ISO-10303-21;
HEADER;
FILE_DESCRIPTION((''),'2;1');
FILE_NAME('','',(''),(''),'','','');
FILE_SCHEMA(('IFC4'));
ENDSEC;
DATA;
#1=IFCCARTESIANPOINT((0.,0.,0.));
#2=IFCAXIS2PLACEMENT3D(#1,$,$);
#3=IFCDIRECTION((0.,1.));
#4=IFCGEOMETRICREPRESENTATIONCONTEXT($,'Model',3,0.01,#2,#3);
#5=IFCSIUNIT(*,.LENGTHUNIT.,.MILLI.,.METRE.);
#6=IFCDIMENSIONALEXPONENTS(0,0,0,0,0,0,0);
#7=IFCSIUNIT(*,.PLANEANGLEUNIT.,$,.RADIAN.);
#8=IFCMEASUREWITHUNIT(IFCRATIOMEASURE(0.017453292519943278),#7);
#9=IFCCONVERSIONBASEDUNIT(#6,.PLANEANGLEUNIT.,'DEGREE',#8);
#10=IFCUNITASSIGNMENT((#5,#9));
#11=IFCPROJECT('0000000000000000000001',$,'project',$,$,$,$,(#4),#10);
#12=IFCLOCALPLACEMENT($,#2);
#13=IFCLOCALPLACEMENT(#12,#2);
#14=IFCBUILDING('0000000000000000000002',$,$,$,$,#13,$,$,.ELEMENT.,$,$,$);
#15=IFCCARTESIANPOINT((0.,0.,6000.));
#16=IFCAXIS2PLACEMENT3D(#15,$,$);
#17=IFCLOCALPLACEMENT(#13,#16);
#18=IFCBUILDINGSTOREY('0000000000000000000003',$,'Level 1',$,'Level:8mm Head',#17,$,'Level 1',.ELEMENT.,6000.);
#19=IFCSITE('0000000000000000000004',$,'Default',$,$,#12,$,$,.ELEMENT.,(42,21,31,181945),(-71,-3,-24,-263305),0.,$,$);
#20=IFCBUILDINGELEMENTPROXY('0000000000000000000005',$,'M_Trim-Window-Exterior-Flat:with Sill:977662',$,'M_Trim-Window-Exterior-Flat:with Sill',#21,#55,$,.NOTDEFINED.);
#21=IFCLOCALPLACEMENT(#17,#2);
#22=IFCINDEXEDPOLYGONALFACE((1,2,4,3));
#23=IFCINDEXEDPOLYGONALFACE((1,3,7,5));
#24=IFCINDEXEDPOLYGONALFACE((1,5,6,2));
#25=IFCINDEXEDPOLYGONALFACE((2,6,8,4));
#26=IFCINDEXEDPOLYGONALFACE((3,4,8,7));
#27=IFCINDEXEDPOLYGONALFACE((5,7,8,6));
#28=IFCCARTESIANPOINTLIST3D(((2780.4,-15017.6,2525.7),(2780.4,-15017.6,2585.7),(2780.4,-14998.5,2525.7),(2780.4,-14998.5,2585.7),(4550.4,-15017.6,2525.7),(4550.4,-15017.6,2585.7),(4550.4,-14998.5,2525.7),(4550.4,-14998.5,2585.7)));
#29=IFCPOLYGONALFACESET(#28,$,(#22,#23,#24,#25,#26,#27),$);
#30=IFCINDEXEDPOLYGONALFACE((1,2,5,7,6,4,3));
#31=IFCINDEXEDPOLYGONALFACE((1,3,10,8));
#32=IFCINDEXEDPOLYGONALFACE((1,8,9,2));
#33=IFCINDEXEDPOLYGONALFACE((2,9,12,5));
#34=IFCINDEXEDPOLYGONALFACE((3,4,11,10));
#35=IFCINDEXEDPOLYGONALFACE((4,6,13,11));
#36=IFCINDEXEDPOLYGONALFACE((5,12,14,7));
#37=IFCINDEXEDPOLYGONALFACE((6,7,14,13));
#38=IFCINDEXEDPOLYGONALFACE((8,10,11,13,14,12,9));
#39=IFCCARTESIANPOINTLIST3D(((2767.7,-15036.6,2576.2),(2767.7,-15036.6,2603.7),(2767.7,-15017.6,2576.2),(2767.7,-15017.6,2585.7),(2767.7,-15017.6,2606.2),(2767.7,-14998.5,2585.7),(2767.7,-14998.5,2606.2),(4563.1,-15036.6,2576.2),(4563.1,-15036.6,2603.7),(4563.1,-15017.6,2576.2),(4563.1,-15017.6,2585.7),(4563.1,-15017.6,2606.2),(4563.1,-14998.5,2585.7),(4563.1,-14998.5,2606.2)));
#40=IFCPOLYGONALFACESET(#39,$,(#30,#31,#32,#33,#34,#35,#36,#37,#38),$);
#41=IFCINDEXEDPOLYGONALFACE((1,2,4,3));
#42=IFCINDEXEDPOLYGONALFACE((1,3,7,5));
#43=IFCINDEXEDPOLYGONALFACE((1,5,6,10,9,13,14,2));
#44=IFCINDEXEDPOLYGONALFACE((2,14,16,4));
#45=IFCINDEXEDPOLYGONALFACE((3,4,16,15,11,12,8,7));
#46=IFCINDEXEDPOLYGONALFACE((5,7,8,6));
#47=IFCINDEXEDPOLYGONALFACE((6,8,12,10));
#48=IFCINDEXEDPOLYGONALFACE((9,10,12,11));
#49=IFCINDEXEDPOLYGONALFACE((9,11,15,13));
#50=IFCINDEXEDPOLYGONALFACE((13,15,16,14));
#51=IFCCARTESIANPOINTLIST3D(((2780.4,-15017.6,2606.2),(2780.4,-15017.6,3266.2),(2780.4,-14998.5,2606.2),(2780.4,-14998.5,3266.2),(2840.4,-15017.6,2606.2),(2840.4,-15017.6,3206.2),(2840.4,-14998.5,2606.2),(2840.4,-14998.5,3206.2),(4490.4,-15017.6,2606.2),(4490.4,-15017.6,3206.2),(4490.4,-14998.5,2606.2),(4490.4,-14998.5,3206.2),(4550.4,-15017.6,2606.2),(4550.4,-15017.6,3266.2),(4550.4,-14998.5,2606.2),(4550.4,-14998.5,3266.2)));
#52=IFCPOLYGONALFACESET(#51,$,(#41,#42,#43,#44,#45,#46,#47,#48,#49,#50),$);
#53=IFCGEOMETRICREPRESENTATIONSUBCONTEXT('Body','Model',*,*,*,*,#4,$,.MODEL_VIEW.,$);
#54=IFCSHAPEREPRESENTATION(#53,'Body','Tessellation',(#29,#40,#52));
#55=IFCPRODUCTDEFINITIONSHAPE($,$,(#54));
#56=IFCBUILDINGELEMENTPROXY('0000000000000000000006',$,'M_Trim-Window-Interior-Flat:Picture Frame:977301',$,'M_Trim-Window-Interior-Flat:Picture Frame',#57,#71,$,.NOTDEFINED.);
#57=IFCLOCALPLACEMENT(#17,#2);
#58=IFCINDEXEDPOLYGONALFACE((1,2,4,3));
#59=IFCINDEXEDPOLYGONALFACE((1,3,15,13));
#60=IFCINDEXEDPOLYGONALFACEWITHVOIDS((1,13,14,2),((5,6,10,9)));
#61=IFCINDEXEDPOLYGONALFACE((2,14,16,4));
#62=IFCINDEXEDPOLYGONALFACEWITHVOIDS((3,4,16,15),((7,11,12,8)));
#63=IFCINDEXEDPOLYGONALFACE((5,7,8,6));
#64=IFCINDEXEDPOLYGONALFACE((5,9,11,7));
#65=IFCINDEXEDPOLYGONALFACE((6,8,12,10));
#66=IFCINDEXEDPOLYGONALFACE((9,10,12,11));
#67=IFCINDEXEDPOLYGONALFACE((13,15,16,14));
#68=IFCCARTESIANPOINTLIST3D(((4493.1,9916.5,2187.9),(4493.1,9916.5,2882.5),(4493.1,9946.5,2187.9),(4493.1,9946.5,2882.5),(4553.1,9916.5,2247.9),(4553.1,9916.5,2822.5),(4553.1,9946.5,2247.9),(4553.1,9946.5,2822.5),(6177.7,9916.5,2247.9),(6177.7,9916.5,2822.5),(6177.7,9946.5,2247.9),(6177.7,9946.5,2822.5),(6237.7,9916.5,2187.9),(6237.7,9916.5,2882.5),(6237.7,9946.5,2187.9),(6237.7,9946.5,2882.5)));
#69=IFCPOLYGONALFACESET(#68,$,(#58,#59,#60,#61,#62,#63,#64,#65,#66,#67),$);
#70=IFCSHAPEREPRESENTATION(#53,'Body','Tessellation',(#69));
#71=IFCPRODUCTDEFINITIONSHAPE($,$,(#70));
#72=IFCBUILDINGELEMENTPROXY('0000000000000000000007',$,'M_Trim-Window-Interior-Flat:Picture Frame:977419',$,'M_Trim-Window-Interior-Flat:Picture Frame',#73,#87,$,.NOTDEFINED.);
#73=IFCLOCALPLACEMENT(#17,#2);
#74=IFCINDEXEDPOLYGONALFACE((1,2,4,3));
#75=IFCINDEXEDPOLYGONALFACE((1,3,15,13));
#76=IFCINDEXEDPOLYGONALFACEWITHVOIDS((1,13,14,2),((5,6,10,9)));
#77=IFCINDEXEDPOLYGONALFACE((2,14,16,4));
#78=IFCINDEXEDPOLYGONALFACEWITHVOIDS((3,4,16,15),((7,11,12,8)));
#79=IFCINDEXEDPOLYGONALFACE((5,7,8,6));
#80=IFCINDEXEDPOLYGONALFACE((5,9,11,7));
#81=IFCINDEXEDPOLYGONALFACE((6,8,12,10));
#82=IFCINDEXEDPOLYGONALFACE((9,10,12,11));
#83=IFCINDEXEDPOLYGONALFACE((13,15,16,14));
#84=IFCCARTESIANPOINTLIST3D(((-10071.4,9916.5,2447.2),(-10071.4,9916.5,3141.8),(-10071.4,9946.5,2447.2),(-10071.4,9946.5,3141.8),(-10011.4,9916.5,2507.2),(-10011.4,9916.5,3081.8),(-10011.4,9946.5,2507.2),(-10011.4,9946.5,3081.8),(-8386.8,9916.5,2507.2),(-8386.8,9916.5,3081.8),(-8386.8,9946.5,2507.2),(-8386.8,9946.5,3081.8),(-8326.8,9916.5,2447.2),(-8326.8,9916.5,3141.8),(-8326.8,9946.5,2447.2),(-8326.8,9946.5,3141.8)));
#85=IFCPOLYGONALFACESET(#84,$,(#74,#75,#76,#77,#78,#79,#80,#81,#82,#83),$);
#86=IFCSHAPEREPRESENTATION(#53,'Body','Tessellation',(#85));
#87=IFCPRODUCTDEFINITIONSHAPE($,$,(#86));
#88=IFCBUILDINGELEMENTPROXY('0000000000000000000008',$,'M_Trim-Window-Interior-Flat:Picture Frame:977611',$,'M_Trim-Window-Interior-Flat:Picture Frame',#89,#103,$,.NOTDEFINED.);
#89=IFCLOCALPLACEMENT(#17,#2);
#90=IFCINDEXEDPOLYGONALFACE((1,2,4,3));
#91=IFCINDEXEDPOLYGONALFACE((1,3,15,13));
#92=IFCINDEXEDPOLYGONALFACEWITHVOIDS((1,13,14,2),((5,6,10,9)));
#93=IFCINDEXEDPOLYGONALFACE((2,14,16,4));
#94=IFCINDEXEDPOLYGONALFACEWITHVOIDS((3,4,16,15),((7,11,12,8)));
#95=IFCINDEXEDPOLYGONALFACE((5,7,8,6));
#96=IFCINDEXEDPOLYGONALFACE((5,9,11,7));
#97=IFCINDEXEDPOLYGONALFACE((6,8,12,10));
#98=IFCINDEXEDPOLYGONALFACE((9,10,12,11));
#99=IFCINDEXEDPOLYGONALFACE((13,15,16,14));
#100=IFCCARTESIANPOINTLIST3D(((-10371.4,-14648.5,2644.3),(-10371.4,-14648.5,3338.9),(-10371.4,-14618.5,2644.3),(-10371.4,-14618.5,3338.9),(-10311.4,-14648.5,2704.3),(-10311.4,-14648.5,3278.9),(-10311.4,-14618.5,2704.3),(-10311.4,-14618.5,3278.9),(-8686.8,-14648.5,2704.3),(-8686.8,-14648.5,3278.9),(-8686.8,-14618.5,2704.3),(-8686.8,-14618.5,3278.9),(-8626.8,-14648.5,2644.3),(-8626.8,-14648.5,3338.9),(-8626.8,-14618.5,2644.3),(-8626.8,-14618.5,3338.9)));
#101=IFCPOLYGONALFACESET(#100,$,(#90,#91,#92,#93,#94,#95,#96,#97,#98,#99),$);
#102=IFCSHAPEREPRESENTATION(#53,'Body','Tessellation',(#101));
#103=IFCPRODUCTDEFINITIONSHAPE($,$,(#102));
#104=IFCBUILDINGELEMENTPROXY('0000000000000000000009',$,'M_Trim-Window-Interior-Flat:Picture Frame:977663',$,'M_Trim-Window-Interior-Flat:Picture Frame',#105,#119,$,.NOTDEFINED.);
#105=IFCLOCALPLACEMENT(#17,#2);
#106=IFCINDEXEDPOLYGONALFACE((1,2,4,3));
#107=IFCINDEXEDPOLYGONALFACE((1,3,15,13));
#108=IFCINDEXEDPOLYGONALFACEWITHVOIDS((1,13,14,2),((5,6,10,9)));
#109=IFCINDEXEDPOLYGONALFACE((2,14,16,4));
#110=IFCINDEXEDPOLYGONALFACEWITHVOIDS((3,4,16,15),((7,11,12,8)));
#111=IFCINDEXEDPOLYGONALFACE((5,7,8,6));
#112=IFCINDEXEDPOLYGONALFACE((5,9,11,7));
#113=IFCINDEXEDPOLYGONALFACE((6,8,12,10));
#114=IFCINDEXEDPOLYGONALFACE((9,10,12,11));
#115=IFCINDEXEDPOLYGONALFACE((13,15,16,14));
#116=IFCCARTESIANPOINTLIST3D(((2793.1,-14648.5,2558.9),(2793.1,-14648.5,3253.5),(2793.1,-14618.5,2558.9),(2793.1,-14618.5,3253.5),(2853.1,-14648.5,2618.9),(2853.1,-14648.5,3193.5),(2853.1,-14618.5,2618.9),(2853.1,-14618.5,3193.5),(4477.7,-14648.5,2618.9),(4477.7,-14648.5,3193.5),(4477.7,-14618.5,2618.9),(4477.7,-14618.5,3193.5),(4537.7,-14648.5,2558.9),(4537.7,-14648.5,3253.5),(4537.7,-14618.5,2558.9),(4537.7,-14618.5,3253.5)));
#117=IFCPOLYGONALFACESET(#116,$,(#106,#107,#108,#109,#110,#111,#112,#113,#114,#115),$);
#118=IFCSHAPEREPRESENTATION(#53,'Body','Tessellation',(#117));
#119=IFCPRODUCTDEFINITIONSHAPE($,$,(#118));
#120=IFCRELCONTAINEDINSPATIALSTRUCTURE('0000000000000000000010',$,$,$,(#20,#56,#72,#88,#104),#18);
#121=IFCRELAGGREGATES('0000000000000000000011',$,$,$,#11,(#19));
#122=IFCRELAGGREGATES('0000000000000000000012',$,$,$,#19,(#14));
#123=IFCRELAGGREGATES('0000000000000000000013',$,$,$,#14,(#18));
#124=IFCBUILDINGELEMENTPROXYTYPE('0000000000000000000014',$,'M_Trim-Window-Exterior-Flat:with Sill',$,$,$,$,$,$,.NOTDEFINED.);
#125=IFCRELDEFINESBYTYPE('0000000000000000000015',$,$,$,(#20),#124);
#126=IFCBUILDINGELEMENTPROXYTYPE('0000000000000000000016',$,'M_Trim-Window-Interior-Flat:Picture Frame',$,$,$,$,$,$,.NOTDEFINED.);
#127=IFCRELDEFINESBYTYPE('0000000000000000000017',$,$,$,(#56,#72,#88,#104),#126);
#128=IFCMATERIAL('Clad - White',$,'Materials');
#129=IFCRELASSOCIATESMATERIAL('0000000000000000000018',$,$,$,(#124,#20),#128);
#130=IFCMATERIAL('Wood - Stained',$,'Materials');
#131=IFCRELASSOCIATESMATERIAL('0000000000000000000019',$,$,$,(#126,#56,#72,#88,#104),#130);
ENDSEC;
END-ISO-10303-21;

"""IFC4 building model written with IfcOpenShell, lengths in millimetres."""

from ifc_helpers import new_model, entity, si_unit, converted_unit, direction, frame, frame_2d, origin, place, context, subcontext, project, spatial, polyline, rectangle, outline, extrude, source, transform, mapped, material, type_object, type_shapes, element, save


model = new_model("IFC4")

# Units and contexts
model_context = context("Model", 3, precision=0.01, world=origin(), true_north=direction((0.0, 1.0)))
body_context = subcontext(model_context, "Body", "Model", "MODEL_VIEW")
ifc_project = project(units=[si_unit("LENGTHUNIT", "METRE", prefix="MILLI"), converted_unit("PLANEANGLEUNIT", "DEGREE", entity("IfcRatioMeasure", 0.017453292519943278), si_unit("PLANEANGLEUNIT", "RADIAN"), dimensions=[0, 0, 0, 0, 0, 0, 0])], contexts=[model_context])

# Site, building, storey
site_placement = place(None, origin())
site = spatial("IfcSite", under=ifc_project, at=site_placement, Name="Default", CompositionType="ELEMENT", RefLatitude=(42, 21, 31, 181945), RefLongitude=(-71, -3, -24, -263305), RefElevation=0.0)
building_placement = place(site_placement, origin())
building = spatial("IfcBuilding", under=site, at=building_placement, CompositionType="ELEMENT")
storey_placement = place(building_placement, frame((0.0, 0.0, 6000.0)))
storey = spatial("IfcBuildingStorey", under=building, at=storey_placement, Name="Level 1", ObjectType="Level:8mm Head", LongName="Level 1", CompositionType="ELEMENT", Elevation=6000.0)

# Building element proxies
ifc_material_1 = material(Name="Clad - White", Category="Materials")
building_element_proxy_type_1 = type_object("IfcBuildingElementProxyType", Name="M_Trim-Window-Exterior-Flat:with Sill", PredefinedType="NOTDEFINED", material=ifc_material_1)
shared_shape_1 = source(origin(), body_context, "Body", "SweptSolid", [
    extrude(rectangle(XDim=1770.0, YDim=60.0, at=frame_2d((0.0, 0.0), x_axis=(1.0, 0.0))), frame((0.0, -650.4, 0.0), z_axis=(0.0, 0.0, 1.0), x_axis=(-1.0, 0.0, 0.0)), (0.0, 0.0, 1.0), 19.0),
    extrude(outline(polyline([(-19.0, -15.2), (0.0, -15.2), (0.0, -5.7), (19.0, -5.7), (19.0, 14.8), (0.0, 14.8), (-19.0, 12.3), (-19.0, -15.2)])), frame((-897.7, -614.8, 19.0), z_axis=(1.0, 0.0, 0.0), x_axis=(0.0, 0.0, -1.0)), (0.0, 0.0, 1.0), 1795.4),
    extrude(outline(polyline([(-345.0, -885.0), (315.0, -885.0), (315.0, -825.0), (-285.0, -825.0), (-285.0, 825.0), (315.0, 825.0), (315.0, 885.0), (-345.0, 885.0), (-345.0, -885.0)])), frame((0.0, -285.0, 0.0), z_axis=(0.0, 0.0, 1.0), x_axis=(0.0, -1.0, 0.0)), (0.0, 0.0, 1.0), 19.0),
])
type_shapes(building_element_proxy_type_1, [shared_shape_1])
for number, where, z_axis, x_axis, name in (
    (1, (3665.4, -14998.5, 3206.2), (0.0, -1.0, 0.0), (1.0, 0.0, 0.0), "M_Trim-Window-Exterior-Flat:with Sill:977662"),
):
    element("IfcBuildingElementProxy", number, at=place(storey_placement, frame(where, z_axis=z_axis, x_axis=x_axis)), inside=storey, type_object=building_element_proxy_type_1, material=ifc_material_1, Name=name, ObjectType="M_Trim-Window-Exterior-Flat:with Sill", PredefinedType="NOTDEFINED", context=body_context, shape_type="MappedRepresentation", body=[
        mapped(shared_shape_1, transform((0.0, 0.0, 0.0), scale=1.0)),
    ])
ifc_material_2 = material(Name="Wood - Stained", Category="Materials")
building_element_proxy_type_2 = type_object("IfcBuildingElementProxyType", Name="M_Trim-Window-Interior-Flat:Picture Frame", PredefinedType="NOTDEFINED", material=ifc_material_2)
shared_shape_2 = source(origin(), body_context, "Body", "SweptSolid", [
    extrude(outline(polyline([(-872.3, -347.3), (872.3, -347.3), (872.3, 347.3), (-872.3, 347.3), (-872.3, -347.3)]), holes=[polyline([(-812.3, -287.3), (-812.3, 287.3), (812.3, 287.3), (812.3, -287.3), (-812.3, -287.3)])]), frame((0.0, -300.0, 0.0), z_axis=(0.0, 0.0, 1.0), x_axis=(-1.0, 0.0, 0.0)), (0.0, 0.0, 1.0), 30.0),
])
type_shapes(building_element_proxy_type_2, [shared_shape_2])
for number, where, z_axis, x_axis, name in (
    (2, (5365.4, 9946.5, 2835.2), (0.0, -1.0, 0.0), (1.0, 0.0, 0.0), "M_Trim-Window-Interior-Flat:Picture Frame:977301"),
    (3, (-9199.1, 9946.5, 3094.5), (0.0, -1.0, 0.0), (1.0, 0.0, 0.0), "M_Trim-Window-Interior-Flat:Picture Frame:977419"),
    (4, (-9499.1, -14648.5, 3291.6), (0.0, 1.0, 0.0), (-1.0, 0.0, 0.0), "M_Trim-Window-Interior-Flat:Picture Frame:977611"),
    (5, (3665.4, -14648.5, 3206.2), (0.0, 1.0, 0.0), (-1.0, 0.0, 0.0), "M_Trim-Window-Interior-Flat:Picture Frame:977663"),
):
    element("IfcBuildingElementProxy", number, at=place(storey_placement, frame(where, z_axis=z_axis, x_axis=x_axis)), inside=storey, type_object=building_element_proxy_type_2, material=ifc_material_2, Name=name, ObjectType="M_Trim-Window-Interior-Flat:Picture Frame", PredefinedType="NOTDEFINED", context=body_context, shape_type="MappedRepresentation", body=[
        mapped(shared_shape_2, transform((0.0, 0.0, 0.0), scale=1.0)),
    ])

save(model, "model.ifc")
